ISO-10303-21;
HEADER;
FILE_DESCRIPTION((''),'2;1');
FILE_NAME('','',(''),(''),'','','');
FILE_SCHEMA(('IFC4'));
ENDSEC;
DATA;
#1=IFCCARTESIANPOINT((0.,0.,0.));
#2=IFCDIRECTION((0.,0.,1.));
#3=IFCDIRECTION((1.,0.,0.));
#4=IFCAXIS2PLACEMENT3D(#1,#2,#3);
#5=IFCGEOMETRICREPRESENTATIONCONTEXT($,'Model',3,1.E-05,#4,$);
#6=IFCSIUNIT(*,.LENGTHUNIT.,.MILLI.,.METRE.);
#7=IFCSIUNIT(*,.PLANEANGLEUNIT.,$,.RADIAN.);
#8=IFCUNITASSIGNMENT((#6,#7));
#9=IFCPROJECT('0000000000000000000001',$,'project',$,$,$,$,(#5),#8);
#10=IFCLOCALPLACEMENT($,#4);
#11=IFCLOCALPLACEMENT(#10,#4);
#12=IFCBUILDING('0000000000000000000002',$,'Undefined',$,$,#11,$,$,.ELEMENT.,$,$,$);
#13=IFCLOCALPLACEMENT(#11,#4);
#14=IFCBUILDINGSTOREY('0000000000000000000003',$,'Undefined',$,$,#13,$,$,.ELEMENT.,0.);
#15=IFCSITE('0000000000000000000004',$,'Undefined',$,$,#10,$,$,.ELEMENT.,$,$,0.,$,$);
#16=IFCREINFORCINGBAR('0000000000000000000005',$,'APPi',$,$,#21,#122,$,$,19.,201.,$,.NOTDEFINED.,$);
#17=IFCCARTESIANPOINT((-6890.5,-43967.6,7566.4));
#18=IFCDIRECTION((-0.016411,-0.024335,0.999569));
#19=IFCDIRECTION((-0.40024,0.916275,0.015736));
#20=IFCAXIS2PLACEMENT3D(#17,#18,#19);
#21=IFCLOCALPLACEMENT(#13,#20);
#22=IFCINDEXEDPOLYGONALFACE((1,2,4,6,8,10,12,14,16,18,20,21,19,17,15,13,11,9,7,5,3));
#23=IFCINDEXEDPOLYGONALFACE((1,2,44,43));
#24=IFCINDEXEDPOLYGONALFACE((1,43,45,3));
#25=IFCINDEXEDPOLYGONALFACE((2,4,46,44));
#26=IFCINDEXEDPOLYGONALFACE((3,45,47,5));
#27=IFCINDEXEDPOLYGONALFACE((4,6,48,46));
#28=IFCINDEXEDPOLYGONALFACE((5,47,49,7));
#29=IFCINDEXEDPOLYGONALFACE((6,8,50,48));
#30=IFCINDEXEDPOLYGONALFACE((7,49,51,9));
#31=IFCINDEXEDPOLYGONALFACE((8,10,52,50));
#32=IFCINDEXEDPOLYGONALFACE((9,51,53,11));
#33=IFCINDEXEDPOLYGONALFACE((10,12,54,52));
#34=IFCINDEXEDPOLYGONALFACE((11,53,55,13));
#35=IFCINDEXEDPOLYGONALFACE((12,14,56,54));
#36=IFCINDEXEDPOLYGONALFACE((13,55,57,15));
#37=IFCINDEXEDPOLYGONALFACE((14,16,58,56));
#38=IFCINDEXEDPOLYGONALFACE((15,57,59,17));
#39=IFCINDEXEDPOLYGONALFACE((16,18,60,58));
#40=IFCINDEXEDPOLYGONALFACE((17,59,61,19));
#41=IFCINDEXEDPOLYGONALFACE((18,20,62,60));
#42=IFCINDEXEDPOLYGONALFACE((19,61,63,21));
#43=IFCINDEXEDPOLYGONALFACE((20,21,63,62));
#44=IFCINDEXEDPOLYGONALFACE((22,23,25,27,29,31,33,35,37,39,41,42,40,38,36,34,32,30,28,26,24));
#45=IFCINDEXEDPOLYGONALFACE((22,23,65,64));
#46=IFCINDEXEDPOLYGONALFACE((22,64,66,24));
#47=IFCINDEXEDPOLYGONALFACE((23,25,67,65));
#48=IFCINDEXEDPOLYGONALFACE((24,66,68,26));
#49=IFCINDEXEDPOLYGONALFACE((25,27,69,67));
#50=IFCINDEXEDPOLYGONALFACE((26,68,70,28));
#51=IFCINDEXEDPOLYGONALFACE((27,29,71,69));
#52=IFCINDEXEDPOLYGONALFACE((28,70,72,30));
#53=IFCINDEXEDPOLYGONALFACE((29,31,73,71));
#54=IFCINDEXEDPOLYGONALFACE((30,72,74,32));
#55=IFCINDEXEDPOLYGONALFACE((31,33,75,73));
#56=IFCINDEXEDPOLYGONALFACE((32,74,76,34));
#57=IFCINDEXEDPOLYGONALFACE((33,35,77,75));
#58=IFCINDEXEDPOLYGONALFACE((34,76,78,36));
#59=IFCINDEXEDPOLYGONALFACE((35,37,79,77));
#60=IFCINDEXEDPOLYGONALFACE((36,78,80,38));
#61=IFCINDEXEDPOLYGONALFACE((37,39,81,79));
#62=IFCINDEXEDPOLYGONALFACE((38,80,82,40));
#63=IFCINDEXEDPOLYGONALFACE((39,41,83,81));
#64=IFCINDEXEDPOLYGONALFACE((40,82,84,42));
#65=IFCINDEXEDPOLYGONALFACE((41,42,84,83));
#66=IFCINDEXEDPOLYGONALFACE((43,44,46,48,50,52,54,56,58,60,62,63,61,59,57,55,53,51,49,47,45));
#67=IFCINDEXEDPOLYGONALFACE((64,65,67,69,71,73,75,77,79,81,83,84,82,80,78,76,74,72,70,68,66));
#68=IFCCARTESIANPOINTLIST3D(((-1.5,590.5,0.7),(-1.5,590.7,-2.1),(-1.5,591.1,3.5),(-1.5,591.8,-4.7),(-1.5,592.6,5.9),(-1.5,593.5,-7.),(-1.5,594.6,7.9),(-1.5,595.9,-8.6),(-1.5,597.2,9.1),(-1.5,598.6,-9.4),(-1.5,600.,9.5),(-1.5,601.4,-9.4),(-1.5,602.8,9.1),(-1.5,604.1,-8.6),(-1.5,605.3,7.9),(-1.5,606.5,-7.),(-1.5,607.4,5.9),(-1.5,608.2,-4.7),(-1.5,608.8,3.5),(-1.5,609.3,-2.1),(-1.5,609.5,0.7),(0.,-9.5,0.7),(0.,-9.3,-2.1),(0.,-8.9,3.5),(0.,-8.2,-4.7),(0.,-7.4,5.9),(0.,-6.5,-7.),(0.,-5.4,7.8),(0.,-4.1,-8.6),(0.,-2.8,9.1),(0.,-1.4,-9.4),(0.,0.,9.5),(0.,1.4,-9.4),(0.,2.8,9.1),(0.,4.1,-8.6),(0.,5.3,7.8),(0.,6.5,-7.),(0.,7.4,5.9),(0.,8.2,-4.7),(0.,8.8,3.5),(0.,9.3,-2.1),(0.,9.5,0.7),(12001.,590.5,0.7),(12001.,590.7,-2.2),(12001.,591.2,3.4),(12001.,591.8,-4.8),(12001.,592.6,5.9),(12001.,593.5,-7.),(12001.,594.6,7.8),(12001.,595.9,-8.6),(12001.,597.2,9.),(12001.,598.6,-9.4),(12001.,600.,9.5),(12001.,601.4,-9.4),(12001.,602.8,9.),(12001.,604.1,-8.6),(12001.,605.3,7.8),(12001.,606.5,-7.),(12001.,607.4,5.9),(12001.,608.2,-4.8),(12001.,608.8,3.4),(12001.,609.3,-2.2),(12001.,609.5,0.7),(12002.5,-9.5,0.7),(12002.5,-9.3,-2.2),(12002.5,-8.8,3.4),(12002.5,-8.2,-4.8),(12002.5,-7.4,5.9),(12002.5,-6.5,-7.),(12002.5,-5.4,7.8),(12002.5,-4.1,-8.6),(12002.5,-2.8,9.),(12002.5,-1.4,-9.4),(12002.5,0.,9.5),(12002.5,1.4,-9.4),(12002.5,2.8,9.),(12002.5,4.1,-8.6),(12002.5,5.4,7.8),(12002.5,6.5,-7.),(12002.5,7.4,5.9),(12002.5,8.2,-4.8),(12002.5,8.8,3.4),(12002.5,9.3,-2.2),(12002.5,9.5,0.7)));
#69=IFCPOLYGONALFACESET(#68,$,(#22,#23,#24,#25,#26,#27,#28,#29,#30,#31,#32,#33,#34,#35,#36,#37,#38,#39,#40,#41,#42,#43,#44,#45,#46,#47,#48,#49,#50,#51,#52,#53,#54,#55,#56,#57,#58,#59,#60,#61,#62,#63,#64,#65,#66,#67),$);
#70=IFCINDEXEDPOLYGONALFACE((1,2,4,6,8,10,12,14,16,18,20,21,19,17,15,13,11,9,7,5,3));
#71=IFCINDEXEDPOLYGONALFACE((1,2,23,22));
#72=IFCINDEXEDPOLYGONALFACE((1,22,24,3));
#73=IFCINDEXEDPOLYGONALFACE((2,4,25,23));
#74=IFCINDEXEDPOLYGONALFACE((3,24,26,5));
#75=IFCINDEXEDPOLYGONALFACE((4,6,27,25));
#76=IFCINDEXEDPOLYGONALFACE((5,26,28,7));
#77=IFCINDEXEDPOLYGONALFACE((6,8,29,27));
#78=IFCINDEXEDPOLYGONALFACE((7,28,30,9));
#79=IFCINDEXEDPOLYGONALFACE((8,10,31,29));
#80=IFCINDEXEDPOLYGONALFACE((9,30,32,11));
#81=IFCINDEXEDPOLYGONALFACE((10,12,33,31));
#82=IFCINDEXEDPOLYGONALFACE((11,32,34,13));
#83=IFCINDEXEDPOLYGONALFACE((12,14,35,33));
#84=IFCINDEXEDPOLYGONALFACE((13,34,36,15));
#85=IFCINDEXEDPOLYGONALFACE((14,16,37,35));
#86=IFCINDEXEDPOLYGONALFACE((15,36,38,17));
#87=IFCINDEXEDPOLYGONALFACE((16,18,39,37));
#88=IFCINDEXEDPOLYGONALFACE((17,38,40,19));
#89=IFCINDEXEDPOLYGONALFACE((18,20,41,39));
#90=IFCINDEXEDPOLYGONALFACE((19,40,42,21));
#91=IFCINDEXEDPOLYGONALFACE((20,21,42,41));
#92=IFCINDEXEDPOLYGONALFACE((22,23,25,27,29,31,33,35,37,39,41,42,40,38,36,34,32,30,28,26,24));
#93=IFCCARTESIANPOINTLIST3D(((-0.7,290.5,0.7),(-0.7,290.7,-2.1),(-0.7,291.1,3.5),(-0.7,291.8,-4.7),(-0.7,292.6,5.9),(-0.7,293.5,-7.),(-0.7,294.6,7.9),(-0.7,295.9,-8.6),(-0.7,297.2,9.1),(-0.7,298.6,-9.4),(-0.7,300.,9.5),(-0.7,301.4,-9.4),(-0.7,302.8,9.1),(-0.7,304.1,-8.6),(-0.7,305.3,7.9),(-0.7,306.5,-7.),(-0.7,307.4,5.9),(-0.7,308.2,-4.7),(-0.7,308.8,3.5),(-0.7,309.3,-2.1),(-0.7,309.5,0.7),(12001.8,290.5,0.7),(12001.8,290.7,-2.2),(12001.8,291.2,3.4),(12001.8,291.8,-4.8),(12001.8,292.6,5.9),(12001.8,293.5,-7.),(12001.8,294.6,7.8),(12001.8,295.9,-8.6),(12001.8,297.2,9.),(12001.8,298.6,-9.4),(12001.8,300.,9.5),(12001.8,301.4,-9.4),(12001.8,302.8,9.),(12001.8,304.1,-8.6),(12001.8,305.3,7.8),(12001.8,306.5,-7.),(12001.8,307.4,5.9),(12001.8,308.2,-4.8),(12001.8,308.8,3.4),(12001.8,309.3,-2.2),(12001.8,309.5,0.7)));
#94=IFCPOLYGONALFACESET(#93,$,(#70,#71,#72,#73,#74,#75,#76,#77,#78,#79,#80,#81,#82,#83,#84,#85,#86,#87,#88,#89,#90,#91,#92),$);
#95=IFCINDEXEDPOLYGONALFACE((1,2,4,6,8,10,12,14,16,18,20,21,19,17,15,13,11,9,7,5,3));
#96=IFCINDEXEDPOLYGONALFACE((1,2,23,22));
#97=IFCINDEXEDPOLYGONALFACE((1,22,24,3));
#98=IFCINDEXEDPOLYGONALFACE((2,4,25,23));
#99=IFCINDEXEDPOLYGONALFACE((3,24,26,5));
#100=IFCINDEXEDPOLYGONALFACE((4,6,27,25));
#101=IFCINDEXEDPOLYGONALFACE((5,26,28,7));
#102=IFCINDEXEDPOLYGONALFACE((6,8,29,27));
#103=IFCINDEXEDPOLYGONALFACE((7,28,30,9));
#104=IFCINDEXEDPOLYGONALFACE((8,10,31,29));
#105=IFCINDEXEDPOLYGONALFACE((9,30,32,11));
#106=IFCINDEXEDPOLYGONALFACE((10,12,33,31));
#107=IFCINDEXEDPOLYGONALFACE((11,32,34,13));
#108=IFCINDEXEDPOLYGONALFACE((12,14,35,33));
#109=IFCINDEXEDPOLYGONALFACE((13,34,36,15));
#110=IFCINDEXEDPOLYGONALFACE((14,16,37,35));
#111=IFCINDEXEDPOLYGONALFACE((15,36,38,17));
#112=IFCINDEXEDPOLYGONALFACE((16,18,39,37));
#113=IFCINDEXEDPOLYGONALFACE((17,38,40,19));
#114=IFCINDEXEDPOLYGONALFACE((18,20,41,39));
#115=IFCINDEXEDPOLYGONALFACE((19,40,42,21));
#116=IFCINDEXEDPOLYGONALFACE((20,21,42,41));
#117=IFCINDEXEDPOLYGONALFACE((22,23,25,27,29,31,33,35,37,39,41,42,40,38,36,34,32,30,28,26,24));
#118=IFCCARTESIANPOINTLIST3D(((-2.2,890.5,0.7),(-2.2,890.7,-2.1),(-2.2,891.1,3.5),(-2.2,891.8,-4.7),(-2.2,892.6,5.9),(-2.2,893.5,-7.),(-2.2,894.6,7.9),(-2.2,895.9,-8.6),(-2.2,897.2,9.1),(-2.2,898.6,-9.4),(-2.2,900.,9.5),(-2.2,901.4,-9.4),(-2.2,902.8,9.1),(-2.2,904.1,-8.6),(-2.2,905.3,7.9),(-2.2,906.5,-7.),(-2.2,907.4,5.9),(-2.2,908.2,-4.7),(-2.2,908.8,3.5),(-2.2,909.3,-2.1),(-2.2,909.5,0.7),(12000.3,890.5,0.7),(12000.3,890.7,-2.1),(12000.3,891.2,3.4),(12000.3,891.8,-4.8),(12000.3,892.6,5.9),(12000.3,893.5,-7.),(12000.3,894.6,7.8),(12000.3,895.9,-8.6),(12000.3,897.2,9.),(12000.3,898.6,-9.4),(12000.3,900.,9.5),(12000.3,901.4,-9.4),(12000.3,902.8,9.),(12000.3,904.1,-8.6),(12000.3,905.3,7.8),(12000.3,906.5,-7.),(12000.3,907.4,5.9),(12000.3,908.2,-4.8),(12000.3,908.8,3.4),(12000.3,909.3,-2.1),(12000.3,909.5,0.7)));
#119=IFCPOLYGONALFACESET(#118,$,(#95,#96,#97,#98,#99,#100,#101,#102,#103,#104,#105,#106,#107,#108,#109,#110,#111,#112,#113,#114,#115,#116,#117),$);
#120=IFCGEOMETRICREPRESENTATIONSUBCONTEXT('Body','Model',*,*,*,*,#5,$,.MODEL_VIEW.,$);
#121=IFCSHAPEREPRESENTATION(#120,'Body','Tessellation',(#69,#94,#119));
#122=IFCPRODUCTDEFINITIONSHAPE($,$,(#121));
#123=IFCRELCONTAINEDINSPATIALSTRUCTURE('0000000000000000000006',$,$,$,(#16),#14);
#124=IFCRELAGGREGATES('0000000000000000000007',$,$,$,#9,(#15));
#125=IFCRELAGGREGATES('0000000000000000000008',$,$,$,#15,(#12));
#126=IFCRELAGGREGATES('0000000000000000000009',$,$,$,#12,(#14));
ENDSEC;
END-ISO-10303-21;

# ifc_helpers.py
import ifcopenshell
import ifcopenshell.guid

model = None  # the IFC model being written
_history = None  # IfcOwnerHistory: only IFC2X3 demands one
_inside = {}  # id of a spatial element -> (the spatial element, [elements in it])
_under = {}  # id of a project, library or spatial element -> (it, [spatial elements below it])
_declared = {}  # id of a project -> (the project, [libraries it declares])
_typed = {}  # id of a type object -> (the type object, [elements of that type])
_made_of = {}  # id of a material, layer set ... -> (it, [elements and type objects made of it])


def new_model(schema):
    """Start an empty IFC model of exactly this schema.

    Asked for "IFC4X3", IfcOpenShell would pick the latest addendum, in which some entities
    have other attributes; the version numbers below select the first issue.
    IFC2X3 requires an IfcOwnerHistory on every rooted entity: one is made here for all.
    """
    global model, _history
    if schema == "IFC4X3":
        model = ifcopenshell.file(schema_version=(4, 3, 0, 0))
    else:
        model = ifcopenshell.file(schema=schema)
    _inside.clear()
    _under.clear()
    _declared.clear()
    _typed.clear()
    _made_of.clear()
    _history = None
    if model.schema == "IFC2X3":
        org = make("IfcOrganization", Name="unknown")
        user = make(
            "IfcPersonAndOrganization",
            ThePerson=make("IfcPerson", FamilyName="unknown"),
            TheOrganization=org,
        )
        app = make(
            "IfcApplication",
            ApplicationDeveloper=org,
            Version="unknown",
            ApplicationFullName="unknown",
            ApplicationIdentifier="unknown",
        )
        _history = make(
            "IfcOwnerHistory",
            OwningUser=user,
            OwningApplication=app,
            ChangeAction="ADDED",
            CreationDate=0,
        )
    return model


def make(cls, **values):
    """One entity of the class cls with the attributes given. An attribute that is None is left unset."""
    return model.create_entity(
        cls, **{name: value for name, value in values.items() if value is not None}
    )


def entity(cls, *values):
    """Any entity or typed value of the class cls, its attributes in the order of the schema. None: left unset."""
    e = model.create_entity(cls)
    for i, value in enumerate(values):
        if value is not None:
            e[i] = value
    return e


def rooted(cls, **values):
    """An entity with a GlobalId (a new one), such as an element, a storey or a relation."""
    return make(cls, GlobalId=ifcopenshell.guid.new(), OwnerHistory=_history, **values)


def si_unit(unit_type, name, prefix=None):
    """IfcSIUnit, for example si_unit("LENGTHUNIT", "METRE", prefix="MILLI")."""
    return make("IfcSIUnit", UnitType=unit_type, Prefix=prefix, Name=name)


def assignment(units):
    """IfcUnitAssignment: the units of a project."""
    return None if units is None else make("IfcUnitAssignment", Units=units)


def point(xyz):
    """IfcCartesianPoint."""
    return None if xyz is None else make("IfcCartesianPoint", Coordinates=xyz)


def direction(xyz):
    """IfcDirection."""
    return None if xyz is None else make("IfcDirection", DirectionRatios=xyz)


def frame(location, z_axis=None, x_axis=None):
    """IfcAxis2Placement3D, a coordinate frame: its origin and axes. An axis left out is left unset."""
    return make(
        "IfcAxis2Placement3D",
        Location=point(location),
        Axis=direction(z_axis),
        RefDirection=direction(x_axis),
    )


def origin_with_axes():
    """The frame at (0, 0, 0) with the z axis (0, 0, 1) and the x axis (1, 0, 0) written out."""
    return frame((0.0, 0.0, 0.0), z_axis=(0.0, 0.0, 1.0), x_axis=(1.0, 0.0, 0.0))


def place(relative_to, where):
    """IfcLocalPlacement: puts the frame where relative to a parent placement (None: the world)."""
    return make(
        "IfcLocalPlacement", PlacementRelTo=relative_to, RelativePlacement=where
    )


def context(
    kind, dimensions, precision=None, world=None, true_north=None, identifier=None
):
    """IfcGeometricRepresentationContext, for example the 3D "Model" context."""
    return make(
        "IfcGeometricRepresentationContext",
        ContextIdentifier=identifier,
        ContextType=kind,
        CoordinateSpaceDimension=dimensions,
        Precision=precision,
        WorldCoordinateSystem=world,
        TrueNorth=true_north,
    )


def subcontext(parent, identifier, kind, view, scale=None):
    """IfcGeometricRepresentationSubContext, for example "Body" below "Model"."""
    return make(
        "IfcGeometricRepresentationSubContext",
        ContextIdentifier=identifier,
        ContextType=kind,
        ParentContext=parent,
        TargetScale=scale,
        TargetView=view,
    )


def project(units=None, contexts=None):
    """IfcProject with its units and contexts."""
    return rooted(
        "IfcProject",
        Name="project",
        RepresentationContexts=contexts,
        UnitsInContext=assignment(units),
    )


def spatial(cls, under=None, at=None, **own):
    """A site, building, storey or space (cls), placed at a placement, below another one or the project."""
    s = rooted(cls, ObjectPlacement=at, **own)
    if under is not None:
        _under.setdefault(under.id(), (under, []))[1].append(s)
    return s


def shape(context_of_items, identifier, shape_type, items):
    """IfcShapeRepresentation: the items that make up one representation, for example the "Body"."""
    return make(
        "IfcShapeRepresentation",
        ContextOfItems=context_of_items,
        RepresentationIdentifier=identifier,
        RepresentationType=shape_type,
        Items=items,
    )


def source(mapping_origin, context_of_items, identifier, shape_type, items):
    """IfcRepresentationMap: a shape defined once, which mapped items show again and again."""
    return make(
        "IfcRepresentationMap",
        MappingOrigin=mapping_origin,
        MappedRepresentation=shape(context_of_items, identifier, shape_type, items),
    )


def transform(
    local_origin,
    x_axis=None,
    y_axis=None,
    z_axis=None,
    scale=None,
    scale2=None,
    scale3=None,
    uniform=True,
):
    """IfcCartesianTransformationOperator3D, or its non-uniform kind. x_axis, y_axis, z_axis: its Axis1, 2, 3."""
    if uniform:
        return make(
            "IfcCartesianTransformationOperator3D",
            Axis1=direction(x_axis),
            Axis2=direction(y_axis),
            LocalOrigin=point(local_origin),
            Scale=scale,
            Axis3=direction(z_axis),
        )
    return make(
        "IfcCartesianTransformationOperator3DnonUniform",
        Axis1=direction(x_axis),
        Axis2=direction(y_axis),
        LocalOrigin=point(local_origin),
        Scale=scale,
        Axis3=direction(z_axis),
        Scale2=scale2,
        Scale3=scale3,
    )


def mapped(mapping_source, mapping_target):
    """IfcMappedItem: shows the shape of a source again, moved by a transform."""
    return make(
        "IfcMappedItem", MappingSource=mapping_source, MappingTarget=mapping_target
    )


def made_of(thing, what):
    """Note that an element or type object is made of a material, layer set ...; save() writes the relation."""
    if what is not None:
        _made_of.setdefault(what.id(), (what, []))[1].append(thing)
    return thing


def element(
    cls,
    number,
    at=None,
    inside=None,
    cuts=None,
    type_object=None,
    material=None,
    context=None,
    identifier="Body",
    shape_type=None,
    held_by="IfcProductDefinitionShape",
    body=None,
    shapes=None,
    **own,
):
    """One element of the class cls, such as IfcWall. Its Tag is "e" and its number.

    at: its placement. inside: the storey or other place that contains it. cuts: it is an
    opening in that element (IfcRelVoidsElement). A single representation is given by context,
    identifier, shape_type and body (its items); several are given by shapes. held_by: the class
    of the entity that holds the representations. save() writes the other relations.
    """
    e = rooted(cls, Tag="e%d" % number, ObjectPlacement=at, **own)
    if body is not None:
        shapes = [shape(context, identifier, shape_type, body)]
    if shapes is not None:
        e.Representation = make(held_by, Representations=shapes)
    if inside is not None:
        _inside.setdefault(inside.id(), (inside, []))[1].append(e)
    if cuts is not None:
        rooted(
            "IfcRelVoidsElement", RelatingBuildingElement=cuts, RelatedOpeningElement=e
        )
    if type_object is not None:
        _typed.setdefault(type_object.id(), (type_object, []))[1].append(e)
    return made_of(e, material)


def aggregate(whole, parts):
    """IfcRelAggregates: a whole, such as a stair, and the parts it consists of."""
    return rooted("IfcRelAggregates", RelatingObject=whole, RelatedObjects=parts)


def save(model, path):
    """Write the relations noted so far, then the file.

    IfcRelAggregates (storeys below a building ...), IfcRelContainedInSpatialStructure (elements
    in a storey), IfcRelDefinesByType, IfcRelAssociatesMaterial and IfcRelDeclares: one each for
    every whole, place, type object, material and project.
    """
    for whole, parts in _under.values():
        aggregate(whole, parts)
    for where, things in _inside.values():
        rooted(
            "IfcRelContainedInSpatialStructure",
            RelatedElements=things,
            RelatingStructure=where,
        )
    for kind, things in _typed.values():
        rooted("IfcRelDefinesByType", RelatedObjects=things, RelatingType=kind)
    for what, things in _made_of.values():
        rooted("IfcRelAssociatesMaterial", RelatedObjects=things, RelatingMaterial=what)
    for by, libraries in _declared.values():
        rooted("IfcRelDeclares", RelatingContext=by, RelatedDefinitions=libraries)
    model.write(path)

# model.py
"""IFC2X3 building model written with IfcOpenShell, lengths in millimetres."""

from ifc_helpers import new_model, entity, si_unit, frame, origin_with_axes, place, context, subcontext, project, spatial, source, transform, mapped, element, save


model = new_model("IFC2X3")

# Units and contexts
model_context = context("Model", 3, precision=1e-05, world=origin_with_axes())
body_context = subcontext(model_context, "Body", "Model", "MODEL_VIEW")
ifc_project = project(units=[si_unit("LENGTHUNIT", "METRE", prefix="MILLI"), si_unit("PLANEANGLEUNIT", "RADIAN")], contexts=[model_context])

# Site, building, storey
site_placement = place(None, origin_with_axes())
site = spatial("IfcSite", under=ifc_project, at=site_placement, Name="Undefined", CompositionType="ELEMENT", RefElevation=0.0)
building_placement = place(site_placement, origin_with_axes())
building = spatial("IfcBuilding", under=site, at=building_placement, Name="Undefined", CompositionType="ELEMENT")
storey_placement = place(building_placement, origin_with_axes())
storey = spatial("IfcBuildingStorey", under=building, at=storey_placement, Name="Undefined", CompositionType="ELEMENT", Elevation=0.0)

# Reinforcing bar
shared_shape_1 = source(origin_with_axes(), body_context, "Body", "AdvancedSweptSolid", [
    entity("IfcSweptDiskSolid", entity("IfcTrimmedCurve", entity("IfcLine", entity("IfcCartesianPoint", [0.0, 0.0, 0.0]), entity("IfcVector", entity("IfcDirection", [1.0, 0.000001, -0.000003]), 1.0)), [entity("IfcParameterValue", 0.0)], [entity("IfcParameterValue", 12002.507574)], True, "PARAMETER"), 9.5, None, 0.0, 12002.5),
])
shared_shape_2 = source(origin_with_axes(), body_context, "Body", "AdvancedSweptSolid", [
    entity("IfcSweptDiskSolid", entity("IfcTrimmedCurve", entity("IfcLine", entity("IfcCartesianPoint", [0.0, 0.0, 0.0]), entity("IfcVector", entity("IfcDirection", [1.0, 0.000001, -0.000003]), 1.0)), [entity("IfcParameterValue", 0.0)], [entity("IfcParameterValue", 12002.507574)], True, "PARAMETER"), 9.5, None, 0.0, 12002.5),
])
shared_shape_3 = source(origin_with_axes(), body_context, "Body", "AdvancedSweptSolid", [
    entity("IfcSweptDiskSolid", entity("IfcTrimmedCurve", entity("IfcLine", entity("IfcCartesianPoint", [0.0, 0.0, 0.0]), entity("IfcVector", entity("IfcDirection", [1.0, 0.000001, -0.000003]), 1.0)), [entity("IfcParameterValue", 0.0)], [entity("IfcParameterValue", 12002.507574)], True, "PARAMETER"), 9.5, None, 0.0, 12002.5),
])
shared_shape_4 = source(origin_with_axes(), body_context, "Body", "AdvancedSweptSolid", [
    entity("IfcSweptDiskSolid", entity("IfcTrimmedCurve", entity("IfcLine", entity("IfcCartesianPoint", [0.0, 0.0, 0.0]), entity("IfcVector", entity("IfcDirection", [1.0, 0.000001, -0.000003]), 1.0)), [entity("IfcParameterValue", 0.0)], [entity("IfcParameterValue", 12002.507574)], True, "PARAMETER"), 9.5, None, 0.0, 12002.5),
])
reinforcing_bar_placement = place(storey_placement, frame((-6890.5, -43967.6, 7566.4), z_axis=(-0.016411, -0.024335, 0.999569), x_axis=(-0.40024, 0.916275, 0.015736)))
element("IfcReinforcingBar", 1, at=reinforcing_bar_placement, inside=storey, Name="APPi", BarRole="NOTDEFINED", CrossSectionArea=201.0, NominalDiameter=19.0, context=body_context, shape_type="MappedRepresentation", body=[
    mapped(shared_shape_1, transform((0.0, 0.0, 0.0))),
    mapped(shared_shape_2, transform((-0.7, 300.0, 0.0))),
    mapped(shared_shape_3, transform((-1.5, 600.0, 0.0))),
    mapped(shared_shape_4, transform((-2.2, 900.0, 0.0))),
])

save(model, "model.ifc")
